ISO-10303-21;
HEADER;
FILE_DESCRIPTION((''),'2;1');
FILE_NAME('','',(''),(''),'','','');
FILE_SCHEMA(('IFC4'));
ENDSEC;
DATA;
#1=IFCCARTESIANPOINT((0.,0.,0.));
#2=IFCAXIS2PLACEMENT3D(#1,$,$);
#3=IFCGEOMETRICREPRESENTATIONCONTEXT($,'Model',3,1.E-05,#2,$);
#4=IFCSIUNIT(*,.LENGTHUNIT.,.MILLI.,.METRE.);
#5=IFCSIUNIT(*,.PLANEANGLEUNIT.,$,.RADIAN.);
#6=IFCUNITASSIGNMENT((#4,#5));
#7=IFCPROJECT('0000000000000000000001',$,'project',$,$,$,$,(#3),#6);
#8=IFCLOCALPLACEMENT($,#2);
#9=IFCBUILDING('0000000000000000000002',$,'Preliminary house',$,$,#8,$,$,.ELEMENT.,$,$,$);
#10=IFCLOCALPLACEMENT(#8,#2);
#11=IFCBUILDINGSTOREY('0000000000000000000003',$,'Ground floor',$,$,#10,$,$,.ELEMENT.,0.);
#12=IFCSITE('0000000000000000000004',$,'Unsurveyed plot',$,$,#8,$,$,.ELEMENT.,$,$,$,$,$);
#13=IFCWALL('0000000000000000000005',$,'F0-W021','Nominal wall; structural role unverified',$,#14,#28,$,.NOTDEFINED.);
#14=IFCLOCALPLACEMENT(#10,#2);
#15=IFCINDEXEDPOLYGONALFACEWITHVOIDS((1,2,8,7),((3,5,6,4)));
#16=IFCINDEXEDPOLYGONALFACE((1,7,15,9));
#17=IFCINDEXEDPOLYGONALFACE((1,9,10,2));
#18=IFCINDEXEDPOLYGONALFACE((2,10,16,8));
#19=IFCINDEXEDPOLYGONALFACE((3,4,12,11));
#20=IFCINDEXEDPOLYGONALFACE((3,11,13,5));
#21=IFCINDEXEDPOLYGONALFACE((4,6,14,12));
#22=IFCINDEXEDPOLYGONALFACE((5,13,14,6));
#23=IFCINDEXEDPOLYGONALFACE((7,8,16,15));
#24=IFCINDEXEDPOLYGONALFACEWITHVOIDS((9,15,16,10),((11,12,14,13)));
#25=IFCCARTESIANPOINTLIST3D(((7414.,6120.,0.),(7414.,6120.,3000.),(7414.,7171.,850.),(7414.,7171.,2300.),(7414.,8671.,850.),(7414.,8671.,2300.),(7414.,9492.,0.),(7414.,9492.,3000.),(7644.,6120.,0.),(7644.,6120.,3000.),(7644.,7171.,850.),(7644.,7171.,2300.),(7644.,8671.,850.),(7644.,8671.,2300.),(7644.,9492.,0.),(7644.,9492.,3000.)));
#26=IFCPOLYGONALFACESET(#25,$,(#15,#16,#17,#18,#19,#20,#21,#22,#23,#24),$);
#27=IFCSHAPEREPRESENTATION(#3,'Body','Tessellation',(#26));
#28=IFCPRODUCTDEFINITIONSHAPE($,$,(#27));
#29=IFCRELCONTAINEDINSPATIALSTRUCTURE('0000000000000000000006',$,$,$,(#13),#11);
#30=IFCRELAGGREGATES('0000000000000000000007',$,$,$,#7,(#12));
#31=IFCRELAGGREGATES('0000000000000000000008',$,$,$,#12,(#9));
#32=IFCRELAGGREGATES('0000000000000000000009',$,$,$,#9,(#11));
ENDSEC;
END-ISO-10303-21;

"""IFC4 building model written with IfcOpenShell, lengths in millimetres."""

from ifc_helpers import new_model, si_unit, frame, origin, place, context, project, spatial, polyline, outline, extrude, element, save


model = new_model("IFC4")

# Units and contexts
model_context = context("Model", 3, precision=1e-05, world=origin())
ifc_project = project(units=[si_unit("LENGTHUNIT", "METRE", prefix="MILLI"), si_unit("PLANEANGLEUNIT", "RADIAN")], contexts=[model_context])

# Site, building, storey
placement_1 = place(None, origin())
site = spatial("IfcSite", under=ifc_project, at=placement_1, Name="Unsurveyed plot", CompositionType="ELEMENT")
building = spatial("IfcBuilding", under=site, at=placement_1, Name="Preliminary house", CompositionType="ELEMENT")
placement_2 = place(placement_1, origin())
storey = spatial("IfcBuildingStorey", under=building, at=placement_2, Name="Ground floor", CompositionType="ELEMENT", Elevation=0.0)

# Wall, opening
wall_1 = element("IfcWall", 1, at=placement_2, inside=storey, Name="F0-W021", Description="Nominal wall; structural role unverified", PredefinedType="NOTDEFINED", context=model_context, shape_type="SweptSolid", body=[
    extrude(outline(polyline([(7414.0, 6120.0), (7414.0, 9492.0), (7644.0, 9492.0), (7644.0, 6120.0), (7414.0, 6120.0)])), origin(), (0.0, 0.0, 1.0), 3000.0),
])
element("IfcOpeningElement", 2, at=placement_2, cuts=wall_1, PredefinedType="OPENING", context=model_context, shape_type="SweptSolid", body=[
    extrude(outline(polyline([(8059.0, 7171.0), (8059.0, 8671.0), (6999.0, 8671.0), (6999.0, 7171.0), (8059.0, 7171.0)])), frame((0.0, 0.0, 850.0)), (0.0, 0.0, 1.0), 1450.0),
])

save(model, "model.ifc")
